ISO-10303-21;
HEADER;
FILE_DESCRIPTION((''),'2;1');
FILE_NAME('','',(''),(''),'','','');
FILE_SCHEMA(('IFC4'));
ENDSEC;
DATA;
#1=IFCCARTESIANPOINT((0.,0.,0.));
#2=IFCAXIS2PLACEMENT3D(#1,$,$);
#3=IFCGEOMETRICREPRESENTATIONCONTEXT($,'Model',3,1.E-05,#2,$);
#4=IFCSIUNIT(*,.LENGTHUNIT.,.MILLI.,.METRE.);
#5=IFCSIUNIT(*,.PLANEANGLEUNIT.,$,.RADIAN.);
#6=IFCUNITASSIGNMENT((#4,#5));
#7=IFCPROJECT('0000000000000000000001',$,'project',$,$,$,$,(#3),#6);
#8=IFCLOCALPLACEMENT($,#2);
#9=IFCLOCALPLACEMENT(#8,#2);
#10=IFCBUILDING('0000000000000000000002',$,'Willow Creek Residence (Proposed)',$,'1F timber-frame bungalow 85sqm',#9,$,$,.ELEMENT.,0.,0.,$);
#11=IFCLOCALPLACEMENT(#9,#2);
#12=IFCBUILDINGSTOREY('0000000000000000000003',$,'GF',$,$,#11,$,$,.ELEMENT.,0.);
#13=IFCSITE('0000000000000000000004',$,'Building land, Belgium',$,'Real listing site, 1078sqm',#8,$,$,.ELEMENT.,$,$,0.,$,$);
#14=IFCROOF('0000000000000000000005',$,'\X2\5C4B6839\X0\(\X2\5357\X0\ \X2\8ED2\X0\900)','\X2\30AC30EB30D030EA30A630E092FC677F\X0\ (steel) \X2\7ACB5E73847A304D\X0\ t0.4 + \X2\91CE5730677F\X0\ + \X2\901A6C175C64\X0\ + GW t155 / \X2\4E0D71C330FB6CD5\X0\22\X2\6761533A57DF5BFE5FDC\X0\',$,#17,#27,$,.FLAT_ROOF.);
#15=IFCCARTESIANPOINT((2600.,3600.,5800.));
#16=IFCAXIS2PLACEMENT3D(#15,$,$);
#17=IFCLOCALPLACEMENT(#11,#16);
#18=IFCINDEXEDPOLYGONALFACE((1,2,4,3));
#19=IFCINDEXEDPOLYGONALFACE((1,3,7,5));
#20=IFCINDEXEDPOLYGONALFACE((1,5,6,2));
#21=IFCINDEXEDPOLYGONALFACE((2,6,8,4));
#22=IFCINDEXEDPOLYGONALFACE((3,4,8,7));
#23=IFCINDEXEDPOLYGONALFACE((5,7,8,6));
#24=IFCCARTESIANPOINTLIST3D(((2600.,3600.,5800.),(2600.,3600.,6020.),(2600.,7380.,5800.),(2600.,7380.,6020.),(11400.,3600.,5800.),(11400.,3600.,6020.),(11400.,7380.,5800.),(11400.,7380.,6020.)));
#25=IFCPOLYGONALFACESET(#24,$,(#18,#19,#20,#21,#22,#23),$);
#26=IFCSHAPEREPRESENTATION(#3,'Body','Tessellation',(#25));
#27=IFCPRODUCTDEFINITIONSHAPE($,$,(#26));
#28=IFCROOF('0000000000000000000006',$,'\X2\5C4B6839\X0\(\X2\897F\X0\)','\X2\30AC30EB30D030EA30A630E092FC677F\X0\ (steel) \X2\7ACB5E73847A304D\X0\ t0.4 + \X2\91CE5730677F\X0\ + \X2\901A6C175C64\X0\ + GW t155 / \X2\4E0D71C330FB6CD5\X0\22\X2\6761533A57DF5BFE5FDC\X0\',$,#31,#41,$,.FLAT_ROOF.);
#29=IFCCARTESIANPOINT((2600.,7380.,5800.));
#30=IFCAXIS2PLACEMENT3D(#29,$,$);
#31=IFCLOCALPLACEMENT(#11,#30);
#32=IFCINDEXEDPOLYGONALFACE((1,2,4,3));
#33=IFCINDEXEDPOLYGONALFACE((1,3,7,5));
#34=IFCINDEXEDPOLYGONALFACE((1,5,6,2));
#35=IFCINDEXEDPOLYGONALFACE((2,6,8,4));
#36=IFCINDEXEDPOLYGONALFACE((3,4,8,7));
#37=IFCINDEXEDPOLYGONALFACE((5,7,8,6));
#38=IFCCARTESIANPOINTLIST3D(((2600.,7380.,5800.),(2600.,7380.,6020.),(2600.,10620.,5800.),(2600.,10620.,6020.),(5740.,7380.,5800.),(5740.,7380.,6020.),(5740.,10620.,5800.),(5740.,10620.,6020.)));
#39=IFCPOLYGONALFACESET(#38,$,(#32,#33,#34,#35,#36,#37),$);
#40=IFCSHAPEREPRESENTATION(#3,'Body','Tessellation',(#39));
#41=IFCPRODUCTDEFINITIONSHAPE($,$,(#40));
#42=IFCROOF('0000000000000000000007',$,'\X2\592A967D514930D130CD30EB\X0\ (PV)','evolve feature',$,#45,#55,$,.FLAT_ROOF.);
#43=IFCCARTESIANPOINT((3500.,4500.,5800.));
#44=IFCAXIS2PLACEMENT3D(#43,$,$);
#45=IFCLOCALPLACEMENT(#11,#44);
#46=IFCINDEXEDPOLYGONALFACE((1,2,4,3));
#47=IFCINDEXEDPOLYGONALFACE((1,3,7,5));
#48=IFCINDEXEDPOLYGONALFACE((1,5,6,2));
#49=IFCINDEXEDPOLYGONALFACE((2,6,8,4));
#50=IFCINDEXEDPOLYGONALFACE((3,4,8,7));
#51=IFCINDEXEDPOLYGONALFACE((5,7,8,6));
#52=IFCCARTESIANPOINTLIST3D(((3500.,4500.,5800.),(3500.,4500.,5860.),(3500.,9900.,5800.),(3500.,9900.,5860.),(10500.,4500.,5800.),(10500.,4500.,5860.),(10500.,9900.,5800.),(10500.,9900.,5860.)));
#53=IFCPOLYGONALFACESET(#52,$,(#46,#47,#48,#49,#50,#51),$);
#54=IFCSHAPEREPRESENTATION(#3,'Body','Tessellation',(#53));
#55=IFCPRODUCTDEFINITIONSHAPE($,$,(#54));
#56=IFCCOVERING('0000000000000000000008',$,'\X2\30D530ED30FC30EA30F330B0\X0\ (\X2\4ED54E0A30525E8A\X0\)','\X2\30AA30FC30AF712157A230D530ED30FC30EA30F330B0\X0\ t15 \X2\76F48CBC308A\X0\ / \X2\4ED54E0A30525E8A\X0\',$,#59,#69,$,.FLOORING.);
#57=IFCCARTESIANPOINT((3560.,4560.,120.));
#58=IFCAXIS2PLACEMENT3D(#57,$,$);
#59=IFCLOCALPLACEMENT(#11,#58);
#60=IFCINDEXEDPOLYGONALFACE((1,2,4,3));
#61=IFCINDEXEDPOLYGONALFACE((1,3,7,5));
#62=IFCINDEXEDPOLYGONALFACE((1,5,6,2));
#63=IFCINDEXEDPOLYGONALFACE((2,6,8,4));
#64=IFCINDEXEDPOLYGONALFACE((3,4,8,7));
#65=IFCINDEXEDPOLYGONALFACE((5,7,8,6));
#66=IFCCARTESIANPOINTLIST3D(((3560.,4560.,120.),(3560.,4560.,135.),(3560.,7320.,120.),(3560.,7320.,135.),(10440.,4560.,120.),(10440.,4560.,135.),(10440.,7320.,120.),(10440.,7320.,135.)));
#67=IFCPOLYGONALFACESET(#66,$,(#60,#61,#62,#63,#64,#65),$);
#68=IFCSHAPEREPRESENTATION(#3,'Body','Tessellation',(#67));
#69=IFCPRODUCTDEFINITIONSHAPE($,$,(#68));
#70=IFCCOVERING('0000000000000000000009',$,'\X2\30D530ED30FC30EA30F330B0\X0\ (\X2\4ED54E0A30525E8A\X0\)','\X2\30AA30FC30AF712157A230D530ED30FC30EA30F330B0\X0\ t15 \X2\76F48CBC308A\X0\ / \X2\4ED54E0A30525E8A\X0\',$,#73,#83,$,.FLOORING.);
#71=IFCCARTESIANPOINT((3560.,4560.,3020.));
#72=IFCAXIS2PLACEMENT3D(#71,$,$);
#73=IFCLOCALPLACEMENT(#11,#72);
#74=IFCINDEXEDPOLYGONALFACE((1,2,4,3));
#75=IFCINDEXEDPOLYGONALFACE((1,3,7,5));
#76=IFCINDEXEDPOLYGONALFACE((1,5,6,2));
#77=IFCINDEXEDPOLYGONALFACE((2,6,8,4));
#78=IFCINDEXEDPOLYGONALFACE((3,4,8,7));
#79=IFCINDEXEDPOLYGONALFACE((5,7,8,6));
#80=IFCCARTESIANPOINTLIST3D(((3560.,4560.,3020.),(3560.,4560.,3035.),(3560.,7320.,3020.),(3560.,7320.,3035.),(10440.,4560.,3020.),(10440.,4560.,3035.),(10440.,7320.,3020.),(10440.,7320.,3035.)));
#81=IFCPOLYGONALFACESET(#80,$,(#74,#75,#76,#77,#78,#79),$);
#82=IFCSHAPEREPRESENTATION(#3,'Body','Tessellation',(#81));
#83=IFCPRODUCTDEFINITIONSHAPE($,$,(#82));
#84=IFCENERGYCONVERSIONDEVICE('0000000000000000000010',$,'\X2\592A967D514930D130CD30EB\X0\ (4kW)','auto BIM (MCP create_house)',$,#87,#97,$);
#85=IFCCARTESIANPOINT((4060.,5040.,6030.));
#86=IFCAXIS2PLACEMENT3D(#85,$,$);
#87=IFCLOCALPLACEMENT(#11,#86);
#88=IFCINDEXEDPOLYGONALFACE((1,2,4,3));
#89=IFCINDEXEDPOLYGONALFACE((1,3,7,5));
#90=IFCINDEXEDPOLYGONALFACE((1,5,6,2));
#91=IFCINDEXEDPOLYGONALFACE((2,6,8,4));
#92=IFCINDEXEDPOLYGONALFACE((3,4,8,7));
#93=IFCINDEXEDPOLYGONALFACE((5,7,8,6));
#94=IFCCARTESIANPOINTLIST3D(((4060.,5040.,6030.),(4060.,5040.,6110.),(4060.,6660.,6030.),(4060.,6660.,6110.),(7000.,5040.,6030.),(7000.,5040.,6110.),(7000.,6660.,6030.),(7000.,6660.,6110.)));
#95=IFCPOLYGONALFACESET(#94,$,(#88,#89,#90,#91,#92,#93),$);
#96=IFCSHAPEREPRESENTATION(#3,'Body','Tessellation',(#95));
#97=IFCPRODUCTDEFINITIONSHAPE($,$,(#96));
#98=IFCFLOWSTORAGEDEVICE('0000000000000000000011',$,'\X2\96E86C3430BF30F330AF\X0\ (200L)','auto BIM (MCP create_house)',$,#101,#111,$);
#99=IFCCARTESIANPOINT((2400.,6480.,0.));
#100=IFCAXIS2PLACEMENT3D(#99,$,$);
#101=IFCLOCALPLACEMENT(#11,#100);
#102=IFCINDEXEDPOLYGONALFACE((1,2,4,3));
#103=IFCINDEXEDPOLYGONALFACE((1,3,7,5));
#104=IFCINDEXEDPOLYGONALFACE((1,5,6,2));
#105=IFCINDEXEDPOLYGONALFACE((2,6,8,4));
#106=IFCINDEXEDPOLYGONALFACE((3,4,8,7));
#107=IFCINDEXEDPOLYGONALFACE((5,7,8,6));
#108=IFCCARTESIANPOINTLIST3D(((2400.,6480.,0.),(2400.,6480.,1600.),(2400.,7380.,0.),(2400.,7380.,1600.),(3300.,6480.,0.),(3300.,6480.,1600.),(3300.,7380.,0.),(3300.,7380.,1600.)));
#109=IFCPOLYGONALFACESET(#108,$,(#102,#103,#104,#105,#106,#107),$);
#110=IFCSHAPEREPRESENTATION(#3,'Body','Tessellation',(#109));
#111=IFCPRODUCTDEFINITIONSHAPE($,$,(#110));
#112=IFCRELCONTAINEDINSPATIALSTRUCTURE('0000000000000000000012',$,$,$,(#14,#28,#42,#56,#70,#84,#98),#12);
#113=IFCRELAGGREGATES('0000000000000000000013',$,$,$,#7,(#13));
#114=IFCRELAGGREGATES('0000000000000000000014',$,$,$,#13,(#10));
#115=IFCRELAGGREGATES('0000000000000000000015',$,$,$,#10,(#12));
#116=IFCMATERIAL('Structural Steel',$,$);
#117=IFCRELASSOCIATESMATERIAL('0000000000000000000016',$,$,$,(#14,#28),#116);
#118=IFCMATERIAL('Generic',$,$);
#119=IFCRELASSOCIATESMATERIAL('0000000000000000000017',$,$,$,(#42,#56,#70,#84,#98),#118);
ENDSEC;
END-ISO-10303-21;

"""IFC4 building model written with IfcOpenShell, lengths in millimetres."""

from ifc_helpers import new_model, si_unit, frame, frame_2d, origin, place, context, project, spatial, rectangle, extrude, material, element, save


model = new_model("IFC4")

# Units and contexts
model_context = context("Model", 3, precision=1e-05, world=origin())
ifc_project = project(units=[si_unit("LENGTHUNIT", "METRE", prefix="MILLI"), si_unit("PLANEANGLEUNIT", "RADIAN")], contexts=[model_context])

# Site, building, storey
site_placement = place(None, origin())
site = spatial("IfcSite", under=ifc_project, at=site_placement, Name="Building land, Belgium", ObjectType="Real listing site, 1078sqm", CompositionType="ELEMENT", RefElevation=0.0)
building_placement = place(site_placement, origin())
building = spatial("IfcBuilding", under=site, at=building_placement, Name="Willow Creek Residence (Proposed)", ObjectType="1F timber-frame bungalow 85sqm", CompositionType="ELEMENT", ElevationOfRefHeight=0.0, ElevationOfTerrain=0.0)
storey_placement = place(building_placement, origin())
storey = spatial("IfcBuildingStorey", under=building, at=storey_placement, Name="GF", CompositionType="ELEMENT", Elevation=0.0)

# Shared definitions
ifc_material_1 = material(Name="Generic")

# Roofs
ifc_material_2 = material(Name="Structural Steel")
roof_1_placement = place(storey_placement, frame((2600.0, 3600.0, 5800.0)))
element("IfcRoof", 1, at=roof_1_placement, inside=storey, material=ifc_material_2, Name="屋根(南 軒900)", Description="ガルバリウム鋼板 (steel) 立平葺き t0.4 + 野地板 + 通気層 + GW t155 / 不燃・法22条区域対応", PredefinedType="FLAT_ROOF", context=model_context, shape_type="SweptSolid", body=[
    extrude(rectangle(XDim=8800.0, YDim=3780.0, at=frame_2d((4400.0, 1890.0))), frame((2600.0, 3600.0, 5800.0)), (0.0, 0.0, 1.0), 220.0),
])
roof_2_placement = place(storey_placement, frame((2600.0, 7380.0, 5800.0)))
element("IfcRoof", 2, at=roof_2_placement, inside=storey, material=ifc_material_2, Name="屋根(西)", Description="ガルバリウム鋼板 (steel) 立平葺き t0.4 + 野地板 + 通気層 + GW t155 / 不燃・法22条区域対応", PredefinedType="FLAT_ROOF", context=model_context, shape_type="SweptSolid", body=[
    extrude(rectangle(XDim=3140.0, YDim=3240.0, at=frame_2d((1570.0, 1620.0))), frame((2600.0, 7380.0, 5800.0)), (0.0, 0.0, 1.0), 220.0),
])
roof_3_placement = place(storey_placement, frame((3500.0, 4500.0, 5800.0)))
element("IfcRoof", 3, at=roof_3_placement, inside=storey, material=ifc_material_1, Name="太陽光パネル (PV)", Description="evolve feature", PredefinedType="FLAT_ROOF", context=model_context, shape_type="SweptSolid", body=[
    extrude(rectangle(XDim=7000.0, YDim=5400.0, at=frame_2d((3500.0, 2700.0))), frame((3500.0, 4500.0, 5800.0)), (0.0, 0.0, 1.0), 60.0),
])

# Coverings
covering_1_placement = place(storey_placement, frame((3560.0, 4560.0, 120.0)))
element("IfcCovering", 4, at=covering_1_placement, inside=storey, material=ifc_material_1, Name="フローリング (仕上げ床)", Description="オーク無垢フローリング t15 直貼り / 仕上げ床", PredefinedType="FLOORING", context=model_context, shape_type="SweptSolid", body=[
    extrude(rectangle(XDim=6880.0, YDim=2760.0, at=frame_2d((3440.0, 1380.0))), frame((3560.0, 4560.0, 120.0)), (0.0, 0.0, 1.0), 15.0),
])
covering_2_placement = place(storey_placement, frame((3560.0, 4560.0, 3020.0)))
element("IfcCovering", 5, at=covering_2_placement, inside=storey, material=ifc_material_1, Name="フローリング (仕上げ床)", Description="オーク無垢フローリング t15 直貼り / 仕上げ床", PredefinedType="FLOORING", context=model_context, shape_type="SweptSolid", body=[
    extrude(rectangle(XDim=6880.0, YDim=2760.0, at=frame_2d((3440.0, 1380.0))), frame((3560.0, 4560.0, 3020.0)), (0.0, 0.0, 1.0), 15.0),
])

# Energy conversion device
energy_conversion_device_placement = place(storey_placement, frame((4060.0, 5040.0, 6030.0)))
element("IfcEnergyConversionDevice", 6, at=energy_conversion_device_placement, inside=storey, material=ifc_material_1, Name="太陽光パネル (4kW)", Description="auto BIM (MCP create_house)", context=model_context, shape_type="SweptSolid", body=[
    extrude(rectangle(XDim=2940.0, YDim=1620.0, at=frame_2d((1470.0, 810.0))), frame((4060.0, 5040.0, 6030.0)), (0.0, 0.0, 1.0), 80.0),
])

# Flow storage device
flow_storage_device_placement = place(storey_placement, frame((2400.0, 6480.0, 0.0)))
element("IfcFlowStorageDevice", 7, at=flow_storage_device_placement, inside=storey, material=ifc_material_1, Name="雨水タンク (200L)", Description="auto BIM (MCP create_house)", context=model_context, shape_type="SweptSolid", body=[
    extrude(rectangle(XDim=900.0, YDim=900.0, at=frame_2d((450.0, 450.0))), frame((2400.0, 6480.0, 0.0)), (0.0, 0.0, 1.0), 1600.0),
])

save(model, "model.ifc")
